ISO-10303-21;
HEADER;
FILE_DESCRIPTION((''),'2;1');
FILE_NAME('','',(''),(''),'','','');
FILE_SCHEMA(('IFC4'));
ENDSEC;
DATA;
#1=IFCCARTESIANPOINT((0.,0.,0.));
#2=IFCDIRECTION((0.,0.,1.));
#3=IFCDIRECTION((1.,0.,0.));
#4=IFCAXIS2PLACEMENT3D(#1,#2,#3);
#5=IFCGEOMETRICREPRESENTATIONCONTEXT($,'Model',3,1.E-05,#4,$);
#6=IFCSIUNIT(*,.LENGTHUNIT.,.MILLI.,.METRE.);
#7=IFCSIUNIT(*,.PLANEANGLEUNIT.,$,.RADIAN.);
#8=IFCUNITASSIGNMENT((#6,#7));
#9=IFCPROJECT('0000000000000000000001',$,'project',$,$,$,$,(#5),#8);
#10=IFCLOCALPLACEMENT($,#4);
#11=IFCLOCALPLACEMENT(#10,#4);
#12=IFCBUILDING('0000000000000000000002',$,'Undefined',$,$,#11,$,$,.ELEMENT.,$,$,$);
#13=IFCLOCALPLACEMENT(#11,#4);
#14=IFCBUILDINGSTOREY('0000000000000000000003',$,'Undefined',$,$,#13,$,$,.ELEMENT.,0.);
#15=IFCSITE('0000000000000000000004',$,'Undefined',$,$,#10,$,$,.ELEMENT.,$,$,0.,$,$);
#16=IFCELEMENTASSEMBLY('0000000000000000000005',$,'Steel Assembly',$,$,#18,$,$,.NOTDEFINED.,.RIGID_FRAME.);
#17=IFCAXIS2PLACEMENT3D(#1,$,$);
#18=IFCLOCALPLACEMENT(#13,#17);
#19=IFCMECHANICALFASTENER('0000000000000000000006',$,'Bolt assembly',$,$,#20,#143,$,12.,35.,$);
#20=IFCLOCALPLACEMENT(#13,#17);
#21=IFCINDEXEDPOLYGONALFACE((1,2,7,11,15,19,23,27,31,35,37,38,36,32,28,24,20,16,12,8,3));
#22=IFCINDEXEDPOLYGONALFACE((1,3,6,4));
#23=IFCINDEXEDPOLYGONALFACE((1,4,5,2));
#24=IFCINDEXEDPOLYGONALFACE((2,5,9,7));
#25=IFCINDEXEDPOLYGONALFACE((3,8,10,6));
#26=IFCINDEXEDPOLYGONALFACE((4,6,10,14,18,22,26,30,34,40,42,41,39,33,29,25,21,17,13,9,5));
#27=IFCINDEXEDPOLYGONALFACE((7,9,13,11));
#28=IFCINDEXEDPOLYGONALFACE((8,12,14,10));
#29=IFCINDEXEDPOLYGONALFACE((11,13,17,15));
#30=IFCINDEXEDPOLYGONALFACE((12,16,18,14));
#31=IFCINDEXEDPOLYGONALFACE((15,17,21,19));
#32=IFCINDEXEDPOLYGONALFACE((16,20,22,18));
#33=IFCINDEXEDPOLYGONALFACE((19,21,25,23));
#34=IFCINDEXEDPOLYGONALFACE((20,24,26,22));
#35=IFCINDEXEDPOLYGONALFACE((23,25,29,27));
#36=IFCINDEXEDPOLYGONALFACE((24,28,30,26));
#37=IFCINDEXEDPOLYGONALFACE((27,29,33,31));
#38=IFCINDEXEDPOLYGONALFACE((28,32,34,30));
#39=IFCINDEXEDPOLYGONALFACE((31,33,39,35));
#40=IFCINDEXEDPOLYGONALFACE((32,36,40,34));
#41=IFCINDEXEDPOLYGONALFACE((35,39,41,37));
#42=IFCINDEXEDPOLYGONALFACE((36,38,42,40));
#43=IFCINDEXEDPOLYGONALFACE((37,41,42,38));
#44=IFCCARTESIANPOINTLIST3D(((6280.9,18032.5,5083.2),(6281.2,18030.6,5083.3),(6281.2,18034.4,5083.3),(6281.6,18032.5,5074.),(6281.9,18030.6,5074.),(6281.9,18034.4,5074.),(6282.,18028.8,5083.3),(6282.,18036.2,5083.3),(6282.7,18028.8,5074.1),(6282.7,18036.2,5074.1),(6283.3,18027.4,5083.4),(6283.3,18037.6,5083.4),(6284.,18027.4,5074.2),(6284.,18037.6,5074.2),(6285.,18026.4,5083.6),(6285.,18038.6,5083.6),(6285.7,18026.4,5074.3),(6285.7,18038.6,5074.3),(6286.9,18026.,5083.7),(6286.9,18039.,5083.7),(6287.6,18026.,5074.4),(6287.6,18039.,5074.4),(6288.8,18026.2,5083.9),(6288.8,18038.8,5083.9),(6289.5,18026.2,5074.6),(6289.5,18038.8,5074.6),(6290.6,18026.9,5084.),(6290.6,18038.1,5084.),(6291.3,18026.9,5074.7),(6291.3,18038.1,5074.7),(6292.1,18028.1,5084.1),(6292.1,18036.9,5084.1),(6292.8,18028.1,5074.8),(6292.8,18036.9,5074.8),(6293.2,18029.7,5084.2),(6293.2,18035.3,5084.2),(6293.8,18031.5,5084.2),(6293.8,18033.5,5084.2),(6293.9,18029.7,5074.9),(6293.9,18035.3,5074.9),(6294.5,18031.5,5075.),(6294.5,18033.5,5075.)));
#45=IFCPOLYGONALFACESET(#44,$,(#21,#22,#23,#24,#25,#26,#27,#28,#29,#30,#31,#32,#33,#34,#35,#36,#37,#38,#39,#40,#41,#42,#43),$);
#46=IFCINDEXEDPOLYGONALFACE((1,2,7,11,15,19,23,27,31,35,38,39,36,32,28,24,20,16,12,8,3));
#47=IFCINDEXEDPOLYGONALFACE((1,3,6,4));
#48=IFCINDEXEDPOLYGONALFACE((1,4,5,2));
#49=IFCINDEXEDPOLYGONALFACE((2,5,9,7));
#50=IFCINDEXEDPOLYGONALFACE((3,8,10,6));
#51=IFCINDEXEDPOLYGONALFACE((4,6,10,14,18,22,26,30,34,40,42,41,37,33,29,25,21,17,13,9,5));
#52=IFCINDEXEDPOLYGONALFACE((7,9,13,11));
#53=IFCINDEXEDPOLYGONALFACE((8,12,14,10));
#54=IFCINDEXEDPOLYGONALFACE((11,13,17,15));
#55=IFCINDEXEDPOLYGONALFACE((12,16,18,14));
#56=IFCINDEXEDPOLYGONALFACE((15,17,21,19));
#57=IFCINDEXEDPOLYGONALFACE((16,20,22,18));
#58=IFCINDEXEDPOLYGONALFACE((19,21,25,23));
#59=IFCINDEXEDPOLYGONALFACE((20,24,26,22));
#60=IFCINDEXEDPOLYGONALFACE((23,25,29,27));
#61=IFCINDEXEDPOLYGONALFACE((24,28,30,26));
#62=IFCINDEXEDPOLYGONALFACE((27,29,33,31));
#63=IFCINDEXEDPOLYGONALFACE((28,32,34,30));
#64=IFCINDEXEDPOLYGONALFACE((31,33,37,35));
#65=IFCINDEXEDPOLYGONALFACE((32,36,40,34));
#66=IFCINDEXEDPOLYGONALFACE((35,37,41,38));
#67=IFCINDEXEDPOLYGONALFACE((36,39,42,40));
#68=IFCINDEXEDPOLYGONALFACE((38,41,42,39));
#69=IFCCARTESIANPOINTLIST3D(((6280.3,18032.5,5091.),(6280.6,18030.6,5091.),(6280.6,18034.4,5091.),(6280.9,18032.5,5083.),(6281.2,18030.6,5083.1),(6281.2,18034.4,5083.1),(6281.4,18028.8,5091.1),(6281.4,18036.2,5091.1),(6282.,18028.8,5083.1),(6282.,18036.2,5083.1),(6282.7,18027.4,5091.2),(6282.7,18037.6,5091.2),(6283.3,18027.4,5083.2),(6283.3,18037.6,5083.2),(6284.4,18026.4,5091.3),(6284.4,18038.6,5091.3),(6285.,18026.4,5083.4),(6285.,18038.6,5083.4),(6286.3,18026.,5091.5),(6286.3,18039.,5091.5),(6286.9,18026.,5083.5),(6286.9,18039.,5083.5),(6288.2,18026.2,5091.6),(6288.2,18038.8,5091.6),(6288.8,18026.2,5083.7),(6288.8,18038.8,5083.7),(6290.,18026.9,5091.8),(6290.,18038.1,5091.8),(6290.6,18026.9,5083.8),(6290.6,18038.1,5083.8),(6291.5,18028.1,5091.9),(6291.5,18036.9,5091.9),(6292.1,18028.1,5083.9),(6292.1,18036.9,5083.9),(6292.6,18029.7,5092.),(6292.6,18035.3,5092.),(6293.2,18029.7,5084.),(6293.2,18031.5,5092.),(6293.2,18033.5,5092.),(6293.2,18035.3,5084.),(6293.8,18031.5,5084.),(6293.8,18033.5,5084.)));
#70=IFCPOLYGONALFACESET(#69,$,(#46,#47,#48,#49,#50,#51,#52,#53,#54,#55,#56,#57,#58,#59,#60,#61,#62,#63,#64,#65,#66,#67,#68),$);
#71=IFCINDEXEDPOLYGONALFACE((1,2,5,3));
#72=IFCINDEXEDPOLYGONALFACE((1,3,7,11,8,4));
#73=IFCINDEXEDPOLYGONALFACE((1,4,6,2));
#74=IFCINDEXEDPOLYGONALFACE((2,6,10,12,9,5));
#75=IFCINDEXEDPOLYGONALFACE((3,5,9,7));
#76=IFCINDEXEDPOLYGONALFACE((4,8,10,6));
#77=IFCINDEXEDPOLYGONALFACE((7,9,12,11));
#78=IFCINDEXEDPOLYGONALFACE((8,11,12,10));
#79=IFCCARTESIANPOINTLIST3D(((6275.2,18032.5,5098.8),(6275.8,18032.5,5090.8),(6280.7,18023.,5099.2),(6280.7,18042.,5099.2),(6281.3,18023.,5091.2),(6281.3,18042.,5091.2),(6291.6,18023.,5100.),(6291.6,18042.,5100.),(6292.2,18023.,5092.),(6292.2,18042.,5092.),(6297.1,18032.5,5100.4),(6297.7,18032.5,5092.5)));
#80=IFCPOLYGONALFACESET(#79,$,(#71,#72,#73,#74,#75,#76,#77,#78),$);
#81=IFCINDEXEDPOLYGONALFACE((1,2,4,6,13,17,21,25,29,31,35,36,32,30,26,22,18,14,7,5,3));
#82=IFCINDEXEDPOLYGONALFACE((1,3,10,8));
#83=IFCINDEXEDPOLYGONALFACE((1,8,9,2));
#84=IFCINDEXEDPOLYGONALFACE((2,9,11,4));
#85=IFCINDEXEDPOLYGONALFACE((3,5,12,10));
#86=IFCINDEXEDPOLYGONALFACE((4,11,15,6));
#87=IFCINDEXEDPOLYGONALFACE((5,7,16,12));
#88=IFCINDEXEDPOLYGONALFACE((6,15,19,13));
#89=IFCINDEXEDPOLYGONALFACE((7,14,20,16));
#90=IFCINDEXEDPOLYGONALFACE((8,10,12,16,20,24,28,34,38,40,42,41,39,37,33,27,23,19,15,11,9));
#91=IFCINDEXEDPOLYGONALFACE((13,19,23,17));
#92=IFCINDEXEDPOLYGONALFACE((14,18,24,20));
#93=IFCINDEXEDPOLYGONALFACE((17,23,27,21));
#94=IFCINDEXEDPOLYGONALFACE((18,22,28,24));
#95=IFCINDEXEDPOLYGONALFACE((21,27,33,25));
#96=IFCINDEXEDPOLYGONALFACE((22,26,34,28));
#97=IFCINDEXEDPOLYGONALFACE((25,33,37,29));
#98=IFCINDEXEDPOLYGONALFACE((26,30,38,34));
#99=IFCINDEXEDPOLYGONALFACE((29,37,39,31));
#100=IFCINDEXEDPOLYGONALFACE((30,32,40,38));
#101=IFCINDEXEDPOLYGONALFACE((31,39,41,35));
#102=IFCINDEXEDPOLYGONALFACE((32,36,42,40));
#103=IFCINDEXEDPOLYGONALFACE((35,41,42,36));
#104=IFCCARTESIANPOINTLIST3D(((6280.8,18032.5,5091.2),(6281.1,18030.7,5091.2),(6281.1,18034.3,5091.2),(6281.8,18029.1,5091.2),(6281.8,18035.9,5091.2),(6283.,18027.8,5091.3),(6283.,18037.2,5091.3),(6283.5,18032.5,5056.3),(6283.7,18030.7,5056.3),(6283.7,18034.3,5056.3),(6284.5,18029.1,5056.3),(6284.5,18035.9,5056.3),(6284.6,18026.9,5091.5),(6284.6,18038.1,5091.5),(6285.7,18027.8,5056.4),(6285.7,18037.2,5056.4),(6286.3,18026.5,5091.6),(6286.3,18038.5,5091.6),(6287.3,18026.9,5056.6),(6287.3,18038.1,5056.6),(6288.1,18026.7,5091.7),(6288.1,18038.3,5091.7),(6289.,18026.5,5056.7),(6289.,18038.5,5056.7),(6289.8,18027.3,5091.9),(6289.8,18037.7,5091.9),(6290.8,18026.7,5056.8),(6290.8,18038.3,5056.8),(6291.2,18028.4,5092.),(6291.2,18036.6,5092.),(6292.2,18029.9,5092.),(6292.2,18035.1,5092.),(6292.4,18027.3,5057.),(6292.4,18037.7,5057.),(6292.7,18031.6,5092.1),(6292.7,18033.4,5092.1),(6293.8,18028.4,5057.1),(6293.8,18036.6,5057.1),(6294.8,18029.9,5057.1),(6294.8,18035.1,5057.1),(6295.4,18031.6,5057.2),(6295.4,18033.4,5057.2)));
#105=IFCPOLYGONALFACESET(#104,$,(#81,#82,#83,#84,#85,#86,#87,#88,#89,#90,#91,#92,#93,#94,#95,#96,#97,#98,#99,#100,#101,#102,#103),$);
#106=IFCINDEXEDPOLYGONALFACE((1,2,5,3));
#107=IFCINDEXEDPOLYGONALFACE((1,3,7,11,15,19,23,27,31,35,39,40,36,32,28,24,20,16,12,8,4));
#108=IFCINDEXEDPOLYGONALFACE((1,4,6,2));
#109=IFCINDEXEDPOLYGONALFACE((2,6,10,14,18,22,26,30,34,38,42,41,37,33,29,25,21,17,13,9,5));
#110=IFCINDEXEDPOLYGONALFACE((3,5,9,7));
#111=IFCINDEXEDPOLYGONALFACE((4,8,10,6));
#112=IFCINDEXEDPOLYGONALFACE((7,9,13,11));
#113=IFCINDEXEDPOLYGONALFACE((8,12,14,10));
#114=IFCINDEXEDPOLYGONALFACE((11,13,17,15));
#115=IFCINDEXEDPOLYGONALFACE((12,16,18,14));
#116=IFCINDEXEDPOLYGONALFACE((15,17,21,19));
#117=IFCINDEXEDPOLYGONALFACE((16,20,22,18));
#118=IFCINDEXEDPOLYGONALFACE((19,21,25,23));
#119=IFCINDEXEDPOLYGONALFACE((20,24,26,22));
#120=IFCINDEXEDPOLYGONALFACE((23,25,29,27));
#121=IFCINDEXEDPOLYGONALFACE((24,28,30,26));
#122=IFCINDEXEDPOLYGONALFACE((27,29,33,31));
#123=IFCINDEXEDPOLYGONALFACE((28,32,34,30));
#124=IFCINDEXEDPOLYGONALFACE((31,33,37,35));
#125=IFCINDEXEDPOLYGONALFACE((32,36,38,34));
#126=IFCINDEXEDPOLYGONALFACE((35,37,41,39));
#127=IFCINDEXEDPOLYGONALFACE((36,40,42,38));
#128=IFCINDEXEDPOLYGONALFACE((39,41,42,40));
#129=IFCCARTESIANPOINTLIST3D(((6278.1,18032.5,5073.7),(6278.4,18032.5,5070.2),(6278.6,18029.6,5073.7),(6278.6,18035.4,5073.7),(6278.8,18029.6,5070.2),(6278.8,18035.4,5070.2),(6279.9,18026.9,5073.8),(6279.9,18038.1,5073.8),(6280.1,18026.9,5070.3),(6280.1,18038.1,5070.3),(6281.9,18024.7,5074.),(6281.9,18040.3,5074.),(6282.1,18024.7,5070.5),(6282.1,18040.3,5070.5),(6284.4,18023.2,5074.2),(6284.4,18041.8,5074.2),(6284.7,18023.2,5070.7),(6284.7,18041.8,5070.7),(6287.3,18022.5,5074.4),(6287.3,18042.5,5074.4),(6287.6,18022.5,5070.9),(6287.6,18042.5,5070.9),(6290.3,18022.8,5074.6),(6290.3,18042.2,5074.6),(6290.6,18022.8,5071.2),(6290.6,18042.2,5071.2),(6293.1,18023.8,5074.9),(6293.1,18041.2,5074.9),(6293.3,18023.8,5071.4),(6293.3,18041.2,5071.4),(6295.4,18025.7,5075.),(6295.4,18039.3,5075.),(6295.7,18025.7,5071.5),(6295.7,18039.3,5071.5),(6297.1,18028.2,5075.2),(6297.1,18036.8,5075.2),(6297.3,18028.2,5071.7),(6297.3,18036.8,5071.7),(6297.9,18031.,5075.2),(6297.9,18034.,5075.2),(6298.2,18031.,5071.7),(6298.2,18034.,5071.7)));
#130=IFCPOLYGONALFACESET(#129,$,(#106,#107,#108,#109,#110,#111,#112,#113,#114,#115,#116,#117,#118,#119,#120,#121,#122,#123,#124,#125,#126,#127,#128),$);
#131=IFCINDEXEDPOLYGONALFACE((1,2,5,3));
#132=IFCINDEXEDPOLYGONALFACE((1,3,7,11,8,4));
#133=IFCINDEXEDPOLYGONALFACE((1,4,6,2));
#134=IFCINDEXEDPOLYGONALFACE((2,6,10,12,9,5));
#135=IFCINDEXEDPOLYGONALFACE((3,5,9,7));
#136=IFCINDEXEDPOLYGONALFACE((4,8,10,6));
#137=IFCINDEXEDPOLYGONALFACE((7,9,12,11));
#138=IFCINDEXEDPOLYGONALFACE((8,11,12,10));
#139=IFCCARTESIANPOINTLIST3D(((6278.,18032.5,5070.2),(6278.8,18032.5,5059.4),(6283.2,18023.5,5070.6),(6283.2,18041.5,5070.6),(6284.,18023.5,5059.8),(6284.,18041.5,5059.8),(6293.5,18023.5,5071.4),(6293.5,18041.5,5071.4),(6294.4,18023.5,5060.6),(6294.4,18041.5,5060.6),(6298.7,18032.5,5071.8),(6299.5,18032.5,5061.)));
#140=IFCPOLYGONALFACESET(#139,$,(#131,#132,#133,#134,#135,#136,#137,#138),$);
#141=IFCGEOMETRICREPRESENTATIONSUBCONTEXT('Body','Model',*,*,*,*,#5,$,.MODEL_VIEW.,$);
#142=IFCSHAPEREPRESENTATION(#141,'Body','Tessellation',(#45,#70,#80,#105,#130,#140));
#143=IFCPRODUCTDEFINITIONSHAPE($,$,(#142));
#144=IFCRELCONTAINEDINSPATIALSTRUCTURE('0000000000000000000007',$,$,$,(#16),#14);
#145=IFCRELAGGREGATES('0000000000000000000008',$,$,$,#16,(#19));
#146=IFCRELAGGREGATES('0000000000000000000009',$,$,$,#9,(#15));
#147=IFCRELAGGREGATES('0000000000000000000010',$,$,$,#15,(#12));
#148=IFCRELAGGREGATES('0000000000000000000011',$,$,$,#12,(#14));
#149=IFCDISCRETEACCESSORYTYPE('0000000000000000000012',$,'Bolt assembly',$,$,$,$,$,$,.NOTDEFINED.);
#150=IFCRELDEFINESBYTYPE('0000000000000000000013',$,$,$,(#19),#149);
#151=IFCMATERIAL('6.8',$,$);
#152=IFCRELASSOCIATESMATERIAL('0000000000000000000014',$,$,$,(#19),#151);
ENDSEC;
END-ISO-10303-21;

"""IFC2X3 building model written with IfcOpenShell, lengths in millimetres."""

from ifc_helpers import new_model, si_unit, frame, origin_with_axes, origin_2d_with_axis, place, context, subcontext, project, spatial, polyline, circle, outline, extrude, source, transform, mapped, material, type_object, element, aggregate, save


model = new_model("IFC2X3")

# Units and contexts
model_context = context("Model", 3, precision=1e-05, world=origin_with_axes())
body_context = subcontext(model_context, "Body", "Model", "MODEL_VIEW")
ifc_project = project(units=[si_unit("LENGTHUNIT", "METRE", prefix="MILLI"), si_unit("PLANEANGLEUNIT", "RADIAN")], contexts=[model_context])

# Site, building, storey
site_placement = place(None, origin_with_axes())
site = spatial("IfcSite", under=ifc_project, at=site_placement, Name="Undefined", CompositionType="ELEMENT", RefElevation=0.0)
building_placement = place(site_placement, origin_with_axes())
building = spatial("IfcBuilding", under=site, at=building_placement, Name="Undefined", CompositionType="ELEMENT")
storey_placement = place(building_placement, origin_with_axes())
storey = spatial("IfcBuildingStorey", under=building, at=storey_placement, Name="Undefined", CompositionType="ELEMENT", Elevation=0.0)

# Element assembly, mechanical fastener
assembly_1_placement = place(storey_placement, origin_with_axes())
assembly_1 = element("IfcElementAssembly", 1, at=assembly_1_placement, inside=storey, Name="Steel Assembly", AssemblyPlace="NOTDEFINED", PredefinedType="RIGID_FRAME")
ifc_material_1 = material(Name="6.8")
discrete_accessory_type_1 = type_object("IfcDiscreteAccessoryType", Name="Bolt assembly")
shared_shape_1 = source(origin_with_axes(), body_context, "Body", "SweptSolid", [
    extrude(circle(Radius=6.5, at=origin_2d_with_axis()), frame((0.0, -0.1, 0.0), z_axis=(0.0, 1.0, 0.0), x_axis=(1.0, 0.0, 0.0)), (0.0, 0.0, 1.0), 9.3),
    extrude(circle(Radius=6.5, at=origin_2d_with_axis()), frame((0.0, -7.9, 0.0), z_axis=(0.0, 1.0, 0.0), x_axis=(1.0, 0.0, 0.0)), (0.0, 0.0, 1.0), 8.0),
    extrude(outline(polyline([(11.0, 0.0), (5.5, 9.5), (-5.5, 9.5), (-11.0, 0.0), (-5.5, -9.5), (5.5, -9.5), (11.0, 0.0)])), frame((0.0, -16.0, 0.0), z_axis=(0.0, 1.0, 0.0), x_axis=(1.0, 0.0, 0.0)), (0.0, 0.0, 1.0), 8.0),
    extrude(circle(Radius=6.0, at=origin_2d_with_axis()), frame((0.0, -8.0, 0.0), z_axis=(0.0, 1.0, 0.0), x_axis=(1.0, 0.0, 0.0)), (0.0, 0.0, 1.0), 35.0),
    extrude(circle(Radius=10.0, at=origin_2d_with_axis()), frame((0.0, 9.2, 0.0), z_axis=(0.0, 1.0, 0.0), x_axis=(1.0, 0.0, 0.0)), (0.0, 0.0, 1.0), 3.5),
    extrude(outline(polyline([(10.4, 0.0), (5.2, 9.0), (-5.2, 9.0), (-10.4, 0.0), (-5.2, -9.0), (5.2, -9.0), (10.4, 0.0)])), frame((0.0, 12.7, 0.0), z_axis=(0.0, 1.0, 0.0), x_axis=(1.0, 0.0, 0.0)), (0.0, 0.0, 1.0), 10.8),
])
mechanical_fastener_1_placement = place(assembly_1_placement, frame((6287.4, 18032.5, 5083.6), z_axis=(0.0, -1.0, 0.0), x_axis=(-0.997054, 0.0, -0.076696)))
mechanical_fastener_1 = element("IfcMechanicalFastener", 2, at=mechanical_fastener_1_placement, type_object=discrete_accessory_type_1, material=ifc_material_1, Name="Bolt assembly", NominalDiameter=12.0, NominalLength=35.0, context=body_context, shape_type="MappedRepresentation", body=[
    mapped(shared_shape_1, transform((0.0, 0.0, 0.0))),
])
aggregate(assembly_1, [mechanical_fastener_1])

save(model, "model.ifc")
